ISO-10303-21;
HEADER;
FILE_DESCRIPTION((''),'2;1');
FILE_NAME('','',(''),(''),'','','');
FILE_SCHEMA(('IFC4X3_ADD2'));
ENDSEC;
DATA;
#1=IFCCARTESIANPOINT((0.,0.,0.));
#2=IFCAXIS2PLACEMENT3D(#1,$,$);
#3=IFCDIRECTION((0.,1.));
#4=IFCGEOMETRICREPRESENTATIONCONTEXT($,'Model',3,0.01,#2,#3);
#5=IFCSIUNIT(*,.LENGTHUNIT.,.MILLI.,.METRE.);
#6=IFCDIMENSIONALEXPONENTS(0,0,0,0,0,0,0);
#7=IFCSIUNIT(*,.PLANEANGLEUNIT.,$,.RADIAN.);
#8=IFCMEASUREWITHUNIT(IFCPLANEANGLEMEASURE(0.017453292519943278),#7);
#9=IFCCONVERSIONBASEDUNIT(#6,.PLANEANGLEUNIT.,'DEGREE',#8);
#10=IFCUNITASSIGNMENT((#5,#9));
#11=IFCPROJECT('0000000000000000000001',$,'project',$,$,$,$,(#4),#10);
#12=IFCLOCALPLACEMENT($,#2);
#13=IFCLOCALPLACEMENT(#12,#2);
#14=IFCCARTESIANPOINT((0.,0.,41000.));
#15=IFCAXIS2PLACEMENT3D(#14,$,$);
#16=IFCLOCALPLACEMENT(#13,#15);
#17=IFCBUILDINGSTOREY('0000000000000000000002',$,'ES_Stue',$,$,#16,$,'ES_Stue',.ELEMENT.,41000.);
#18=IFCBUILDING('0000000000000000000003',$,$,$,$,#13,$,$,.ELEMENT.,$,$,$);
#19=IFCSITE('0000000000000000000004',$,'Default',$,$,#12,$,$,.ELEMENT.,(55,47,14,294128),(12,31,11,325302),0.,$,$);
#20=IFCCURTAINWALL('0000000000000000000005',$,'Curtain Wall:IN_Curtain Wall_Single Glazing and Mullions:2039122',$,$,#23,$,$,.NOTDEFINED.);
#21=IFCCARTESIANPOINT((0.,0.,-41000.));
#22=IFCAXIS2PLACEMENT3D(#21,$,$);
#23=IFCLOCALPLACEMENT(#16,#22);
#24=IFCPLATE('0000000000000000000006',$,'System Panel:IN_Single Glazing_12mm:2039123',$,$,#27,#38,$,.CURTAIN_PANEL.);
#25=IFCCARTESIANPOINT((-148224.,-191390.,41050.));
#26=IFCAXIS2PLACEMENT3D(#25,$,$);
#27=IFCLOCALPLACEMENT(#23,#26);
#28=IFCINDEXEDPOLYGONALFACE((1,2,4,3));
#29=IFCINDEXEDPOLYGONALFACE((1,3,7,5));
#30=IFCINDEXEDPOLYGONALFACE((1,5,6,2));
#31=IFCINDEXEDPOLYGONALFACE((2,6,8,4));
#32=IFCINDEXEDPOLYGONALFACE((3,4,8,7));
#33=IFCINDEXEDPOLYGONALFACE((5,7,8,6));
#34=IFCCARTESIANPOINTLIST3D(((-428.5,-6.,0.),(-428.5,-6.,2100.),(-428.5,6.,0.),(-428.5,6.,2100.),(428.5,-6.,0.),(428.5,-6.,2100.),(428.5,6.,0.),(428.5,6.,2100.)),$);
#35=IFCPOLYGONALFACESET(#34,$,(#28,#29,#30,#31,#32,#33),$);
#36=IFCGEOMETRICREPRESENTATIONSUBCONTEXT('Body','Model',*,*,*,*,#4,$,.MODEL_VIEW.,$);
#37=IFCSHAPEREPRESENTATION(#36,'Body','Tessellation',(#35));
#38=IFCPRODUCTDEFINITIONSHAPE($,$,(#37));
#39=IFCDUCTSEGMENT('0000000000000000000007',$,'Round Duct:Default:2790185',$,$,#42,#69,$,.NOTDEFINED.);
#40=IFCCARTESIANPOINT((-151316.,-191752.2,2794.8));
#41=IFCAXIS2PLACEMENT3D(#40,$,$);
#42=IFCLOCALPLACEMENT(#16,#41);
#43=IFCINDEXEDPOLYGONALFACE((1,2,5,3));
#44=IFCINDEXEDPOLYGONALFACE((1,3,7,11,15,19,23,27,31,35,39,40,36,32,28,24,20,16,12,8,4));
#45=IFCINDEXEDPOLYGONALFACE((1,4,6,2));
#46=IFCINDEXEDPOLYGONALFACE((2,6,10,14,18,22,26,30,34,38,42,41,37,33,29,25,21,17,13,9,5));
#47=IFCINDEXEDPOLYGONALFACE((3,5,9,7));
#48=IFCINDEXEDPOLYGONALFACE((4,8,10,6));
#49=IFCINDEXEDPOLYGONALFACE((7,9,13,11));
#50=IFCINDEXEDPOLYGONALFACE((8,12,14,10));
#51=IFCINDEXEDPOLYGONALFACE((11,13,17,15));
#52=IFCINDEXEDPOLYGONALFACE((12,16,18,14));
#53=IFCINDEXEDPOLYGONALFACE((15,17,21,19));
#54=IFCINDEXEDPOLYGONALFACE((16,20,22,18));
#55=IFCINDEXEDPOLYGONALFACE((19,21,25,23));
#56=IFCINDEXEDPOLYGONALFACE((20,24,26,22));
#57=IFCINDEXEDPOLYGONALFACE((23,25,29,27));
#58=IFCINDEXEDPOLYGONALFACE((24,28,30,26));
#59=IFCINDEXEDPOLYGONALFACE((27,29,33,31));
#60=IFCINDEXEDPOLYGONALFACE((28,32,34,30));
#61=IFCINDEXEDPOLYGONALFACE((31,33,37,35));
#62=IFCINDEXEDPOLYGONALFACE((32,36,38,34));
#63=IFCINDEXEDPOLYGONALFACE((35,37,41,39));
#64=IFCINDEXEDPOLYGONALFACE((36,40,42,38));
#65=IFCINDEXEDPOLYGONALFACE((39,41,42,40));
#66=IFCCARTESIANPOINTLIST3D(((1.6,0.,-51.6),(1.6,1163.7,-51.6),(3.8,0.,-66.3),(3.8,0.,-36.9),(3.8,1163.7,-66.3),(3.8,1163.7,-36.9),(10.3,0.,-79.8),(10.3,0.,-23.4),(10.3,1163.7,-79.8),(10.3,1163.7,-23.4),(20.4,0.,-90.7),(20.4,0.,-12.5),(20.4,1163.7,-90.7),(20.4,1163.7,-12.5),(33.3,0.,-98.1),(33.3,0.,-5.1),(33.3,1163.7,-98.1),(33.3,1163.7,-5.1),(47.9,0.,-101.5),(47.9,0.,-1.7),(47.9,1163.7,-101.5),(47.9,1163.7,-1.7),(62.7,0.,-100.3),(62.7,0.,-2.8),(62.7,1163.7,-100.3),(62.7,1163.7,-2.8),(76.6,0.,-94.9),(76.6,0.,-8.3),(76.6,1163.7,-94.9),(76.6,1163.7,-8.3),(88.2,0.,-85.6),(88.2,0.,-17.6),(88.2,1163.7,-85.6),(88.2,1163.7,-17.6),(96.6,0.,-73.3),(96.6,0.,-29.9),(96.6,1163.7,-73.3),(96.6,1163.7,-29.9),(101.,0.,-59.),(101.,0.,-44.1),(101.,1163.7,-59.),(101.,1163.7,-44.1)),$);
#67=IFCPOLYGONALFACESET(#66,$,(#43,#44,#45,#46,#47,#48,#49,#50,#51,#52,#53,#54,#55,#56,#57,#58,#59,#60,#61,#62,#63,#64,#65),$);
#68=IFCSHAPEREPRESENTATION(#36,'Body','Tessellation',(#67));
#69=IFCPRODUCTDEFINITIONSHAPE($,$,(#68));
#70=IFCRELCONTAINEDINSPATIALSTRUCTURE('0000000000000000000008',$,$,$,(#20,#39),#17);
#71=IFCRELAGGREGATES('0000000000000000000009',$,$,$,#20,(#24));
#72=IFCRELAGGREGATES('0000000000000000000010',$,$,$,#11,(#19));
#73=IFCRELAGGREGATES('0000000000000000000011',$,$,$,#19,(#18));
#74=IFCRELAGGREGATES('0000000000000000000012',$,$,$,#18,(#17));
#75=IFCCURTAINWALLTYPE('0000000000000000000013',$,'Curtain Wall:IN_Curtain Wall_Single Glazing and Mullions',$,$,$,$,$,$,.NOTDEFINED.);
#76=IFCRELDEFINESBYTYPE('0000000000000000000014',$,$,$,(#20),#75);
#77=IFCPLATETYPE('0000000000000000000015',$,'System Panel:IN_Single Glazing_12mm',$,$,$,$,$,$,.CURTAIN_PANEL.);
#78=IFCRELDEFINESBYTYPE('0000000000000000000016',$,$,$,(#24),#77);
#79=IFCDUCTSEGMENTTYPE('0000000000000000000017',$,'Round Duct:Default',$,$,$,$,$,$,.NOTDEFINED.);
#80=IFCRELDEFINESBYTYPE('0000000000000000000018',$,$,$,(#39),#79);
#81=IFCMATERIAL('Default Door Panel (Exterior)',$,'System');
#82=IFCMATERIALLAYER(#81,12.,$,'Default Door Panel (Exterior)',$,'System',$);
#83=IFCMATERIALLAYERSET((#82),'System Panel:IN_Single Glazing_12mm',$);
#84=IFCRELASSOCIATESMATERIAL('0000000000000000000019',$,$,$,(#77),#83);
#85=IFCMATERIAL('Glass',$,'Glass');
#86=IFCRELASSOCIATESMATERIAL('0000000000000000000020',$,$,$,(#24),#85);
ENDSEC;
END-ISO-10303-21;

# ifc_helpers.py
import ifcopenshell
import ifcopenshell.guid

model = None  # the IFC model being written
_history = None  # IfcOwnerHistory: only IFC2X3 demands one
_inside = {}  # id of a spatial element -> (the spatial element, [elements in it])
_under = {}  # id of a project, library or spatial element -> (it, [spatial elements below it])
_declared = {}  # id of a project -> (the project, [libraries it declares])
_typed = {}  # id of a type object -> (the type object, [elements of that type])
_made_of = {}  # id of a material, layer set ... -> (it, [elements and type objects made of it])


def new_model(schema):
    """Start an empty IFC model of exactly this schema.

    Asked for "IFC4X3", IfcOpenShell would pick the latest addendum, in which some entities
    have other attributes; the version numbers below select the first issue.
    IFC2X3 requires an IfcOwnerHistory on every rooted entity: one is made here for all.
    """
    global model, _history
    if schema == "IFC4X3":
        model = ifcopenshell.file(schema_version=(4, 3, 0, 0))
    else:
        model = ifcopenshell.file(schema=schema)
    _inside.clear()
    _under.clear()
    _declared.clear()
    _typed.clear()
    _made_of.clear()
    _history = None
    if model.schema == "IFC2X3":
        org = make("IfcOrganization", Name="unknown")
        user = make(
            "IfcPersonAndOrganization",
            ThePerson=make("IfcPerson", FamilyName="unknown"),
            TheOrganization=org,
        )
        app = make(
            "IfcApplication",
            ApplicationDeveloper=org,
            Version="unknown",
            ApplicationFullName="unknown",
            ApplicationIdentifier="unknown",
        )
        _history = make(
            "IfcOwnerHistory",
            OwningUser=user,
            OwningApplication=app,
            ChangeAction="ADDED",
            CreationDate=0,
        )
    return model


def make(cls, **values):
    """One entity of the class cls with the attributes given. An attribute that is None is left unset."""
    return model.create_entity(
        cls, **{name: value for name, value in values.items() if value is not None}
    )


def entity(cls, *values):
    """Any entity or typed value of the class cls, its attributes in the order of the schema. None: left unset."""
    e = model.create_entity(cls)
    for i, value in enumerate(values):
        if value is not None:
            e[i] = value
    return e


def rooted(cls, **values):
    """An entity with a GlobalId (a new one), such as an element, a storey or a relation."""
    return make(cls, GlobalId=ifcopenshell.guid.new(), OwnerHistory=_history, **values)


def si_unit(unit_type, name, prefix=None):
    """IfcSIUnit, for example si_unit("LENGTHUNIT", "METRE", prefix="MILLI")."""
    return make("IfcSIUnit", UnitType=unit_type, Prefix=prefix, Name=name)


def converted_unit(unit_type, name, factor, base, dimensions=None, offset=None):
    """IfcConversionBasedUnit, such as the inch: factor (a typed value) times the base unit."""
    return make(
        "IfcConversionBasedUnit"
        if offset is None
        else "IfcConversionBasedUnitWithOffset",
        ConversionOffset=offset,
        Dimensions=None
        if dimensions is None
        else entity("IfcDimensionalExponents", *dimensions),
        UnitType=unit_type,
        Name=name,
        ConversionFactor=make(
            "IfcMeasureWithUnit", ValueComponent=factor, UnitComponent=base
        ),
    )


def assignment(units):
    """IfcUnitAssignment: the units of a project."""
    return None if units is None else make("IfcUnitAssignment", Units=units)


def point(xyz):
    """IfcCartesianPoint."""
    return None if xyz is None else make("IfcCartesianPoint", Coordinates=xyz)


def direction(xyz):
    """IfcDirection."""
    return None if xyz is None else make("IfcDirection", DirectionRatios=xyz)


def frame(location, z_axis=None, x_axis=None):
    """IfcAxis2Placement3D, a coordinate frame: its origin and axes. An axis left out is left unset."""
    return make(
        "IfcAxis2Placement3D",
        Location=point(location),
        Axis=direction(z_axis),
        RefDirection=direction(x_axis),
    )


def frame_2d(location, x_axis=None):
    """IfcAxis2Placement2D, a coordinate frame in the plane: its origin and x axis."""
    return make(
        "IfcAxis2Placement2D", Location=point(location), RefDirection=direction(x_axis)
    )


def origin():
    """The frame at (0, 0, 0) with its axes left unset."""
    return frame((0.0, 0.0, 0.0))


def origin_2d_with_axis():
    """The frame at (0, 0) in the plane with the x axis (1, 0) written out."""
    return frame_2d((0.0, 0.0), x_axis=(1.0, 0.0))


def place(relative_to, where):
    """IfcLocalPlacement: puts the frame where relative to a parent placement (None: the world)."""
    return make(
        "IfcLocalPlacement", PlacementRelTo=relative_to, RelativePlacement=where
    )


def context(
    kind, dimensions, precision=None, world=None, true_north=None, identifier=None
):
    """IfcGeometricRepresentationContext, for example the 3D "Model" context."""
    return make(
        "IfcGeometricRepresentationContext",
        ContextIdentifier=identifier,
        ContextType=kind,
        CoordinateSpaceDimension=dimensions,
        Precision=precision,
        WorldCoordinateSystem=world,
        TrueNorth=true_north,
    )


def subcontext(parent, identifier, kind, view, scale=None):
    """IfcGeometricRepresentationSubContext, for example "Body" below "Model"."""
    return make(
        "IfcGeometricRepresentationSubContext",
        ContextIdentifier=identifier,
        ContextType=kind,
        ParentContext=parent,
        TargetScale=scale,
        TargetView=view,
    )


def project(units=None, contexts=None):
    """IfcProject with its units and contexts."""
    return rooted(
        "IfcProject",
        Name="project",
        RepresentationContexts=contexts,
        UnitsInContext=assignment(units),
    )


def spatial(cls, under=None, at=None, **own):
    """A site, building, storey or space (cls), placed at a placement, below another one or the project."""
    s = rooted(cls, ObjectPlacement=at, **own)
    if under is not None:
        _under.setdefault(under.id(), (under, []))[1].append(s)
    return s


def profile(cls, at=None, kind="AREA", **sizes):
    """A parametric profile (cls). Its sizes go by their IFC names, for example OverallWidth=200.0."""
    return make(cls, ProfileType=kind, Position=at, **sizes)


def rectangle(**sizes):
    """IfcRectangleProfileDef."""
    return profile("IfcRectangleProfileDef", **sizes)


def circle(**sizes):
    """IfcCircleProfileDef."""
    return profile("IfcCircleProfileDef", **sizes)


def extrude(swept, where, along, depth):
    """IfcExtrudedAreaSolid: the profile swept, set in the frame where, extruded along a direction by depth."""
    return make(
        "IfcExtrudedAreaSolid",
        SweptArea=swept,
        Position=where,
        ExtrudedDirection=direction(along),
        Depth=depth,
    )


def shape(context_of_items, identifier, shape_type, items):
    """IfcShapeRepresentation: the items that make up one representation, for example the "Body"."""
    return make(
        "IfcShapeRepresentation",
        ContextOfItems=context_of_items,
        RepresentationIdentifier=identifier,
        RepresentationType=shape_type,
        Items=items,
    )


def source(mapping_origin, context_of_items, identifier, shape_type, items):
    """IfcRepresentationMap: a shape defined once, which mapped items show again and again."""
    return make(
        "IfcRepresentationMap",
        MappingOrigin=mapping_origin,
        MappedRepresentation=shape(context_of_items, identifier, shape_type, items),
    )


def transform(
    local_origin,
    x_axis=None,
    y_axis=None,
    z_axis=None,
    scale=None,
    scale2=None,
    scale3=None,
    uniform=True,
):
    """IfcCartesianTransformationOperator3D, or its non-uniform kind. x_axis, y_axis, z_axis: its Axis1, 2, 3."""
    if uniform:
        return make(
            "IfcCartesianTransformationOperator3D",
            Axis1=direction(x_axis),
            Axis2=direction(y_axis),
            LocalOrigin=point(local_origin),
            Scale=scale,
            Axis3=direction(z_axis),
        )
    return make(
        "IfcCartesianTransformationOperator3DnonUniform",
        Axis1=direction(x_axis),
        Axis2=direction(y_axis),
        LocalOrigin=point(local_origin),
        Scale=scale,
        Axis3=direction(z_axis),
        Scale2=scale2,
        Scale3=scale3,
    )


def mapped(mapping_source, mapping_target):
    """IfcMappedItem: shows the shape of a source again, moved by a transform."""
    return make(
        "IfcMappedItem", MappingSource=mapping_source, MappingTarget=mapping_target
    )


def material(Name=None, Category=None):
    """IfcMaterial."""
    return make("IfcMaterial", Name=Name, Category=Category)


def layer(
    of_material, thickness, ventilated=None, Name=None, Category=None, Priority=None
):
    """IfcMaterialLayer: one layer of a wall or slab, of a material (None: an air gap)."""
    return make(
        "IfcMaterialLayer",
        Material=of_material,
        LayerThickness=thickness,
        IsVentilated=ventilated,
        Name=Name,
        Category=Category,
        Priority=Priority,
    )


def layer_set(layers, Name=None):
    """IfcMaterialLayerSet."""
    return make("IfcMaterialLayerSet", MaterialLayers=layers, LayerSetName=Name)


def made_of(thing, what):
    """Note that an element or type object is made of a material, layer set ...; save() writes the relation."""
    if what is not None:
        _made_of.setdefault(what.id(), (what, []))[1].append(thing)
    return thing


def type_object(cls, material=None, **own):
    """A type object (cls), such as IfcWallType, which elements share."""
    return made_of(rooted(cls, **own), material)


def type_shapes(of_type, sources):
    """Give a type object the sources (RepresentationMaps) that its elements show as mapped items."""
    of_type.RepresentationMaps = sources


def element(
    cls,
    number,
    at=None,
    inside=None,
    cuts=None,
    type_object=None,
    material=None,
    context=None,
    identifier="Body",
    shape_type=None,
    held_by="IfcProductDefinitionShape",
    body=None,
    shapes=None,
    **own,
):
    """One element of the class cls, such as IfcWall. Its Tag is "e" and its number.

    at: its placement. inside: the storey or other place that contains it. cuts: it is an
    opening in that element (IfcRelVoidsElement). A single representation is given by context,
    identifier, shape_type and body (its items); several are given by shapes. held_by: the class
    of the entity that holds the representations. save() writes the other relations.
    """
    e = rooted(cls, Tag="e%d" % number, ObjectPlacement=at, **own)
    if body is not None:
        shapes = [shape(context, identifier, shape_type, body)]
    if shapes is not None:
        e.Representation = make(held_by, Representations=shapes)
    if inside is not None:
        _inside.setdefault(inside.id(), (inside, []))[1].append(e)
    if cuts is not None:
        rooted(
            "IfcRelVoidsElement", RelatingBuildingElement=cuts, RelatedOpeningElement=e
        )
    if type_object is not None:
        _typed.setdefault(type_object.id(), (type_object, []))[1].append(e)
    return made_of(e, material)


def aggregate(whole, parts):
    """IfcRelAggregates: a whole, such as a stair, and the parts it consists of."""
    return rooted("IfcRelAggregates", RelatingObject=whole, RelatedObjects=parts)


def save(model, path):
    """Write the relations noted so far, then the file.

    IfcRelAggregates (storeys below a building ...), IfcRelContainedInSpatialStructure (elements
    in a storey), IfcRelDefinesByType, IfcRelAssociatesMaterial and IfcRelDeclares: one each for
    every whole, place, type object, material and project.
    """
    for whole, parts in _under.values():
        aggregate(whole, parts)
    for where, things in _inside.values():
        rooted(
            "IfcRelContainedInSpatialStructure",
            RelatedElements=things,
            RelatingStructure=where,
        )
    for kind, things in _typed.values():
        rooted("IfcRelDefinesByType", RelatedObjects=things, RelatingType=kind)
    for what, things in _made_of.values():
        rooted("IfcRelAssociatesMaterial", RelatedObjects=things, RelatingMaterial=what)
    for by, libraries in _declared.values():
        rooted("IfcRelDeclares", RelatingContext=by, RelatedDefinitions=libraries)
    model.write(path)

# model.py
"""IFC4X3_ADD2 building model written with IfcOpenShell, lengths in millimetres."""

from ifc_helpers import new_model, entity, si_unit, converted_unit, direction, frame, frame_2d, origin, origin_2d_with_axis, place, context, subcontext, project, spatial, rectangle, circle, extrude, source, transform, mapped, material, layer, layer_set, type_object, type_shapes, element, aggregate, save


model = new_model("IFC4X3_ADD2")

# Units and contexts
model_context = context("Model", 3, precision=0.01, world=origin(), true_north=direction((0.0, 1.0)))
body_context = subcontext(model_context, "Body", "Model", "MODEL_VIEW")
ifc_project = project(units=[si_unit("LENGTHUNIT", "METRE", prefix="MILLI"), converted_unit("PLANEANGLEUNIT", "DEGREE", entity("IfcPlaneAngleMeasure", 0.017453292519943278), si_unit("PLANEANGLEUNIT", "RADIAN"), dimensions=[0, 0, 0, 0, 0, 0, 0])], contexts=[model_context])

# Site, building, storey
site_placement = place(None, origin())
site = spatial("IfcSite", under=ifc_project, at=site_placement, Name="Default", CompositionType="ELEMENT", RefLatitude=(55, 47, 14, 294128), RefLongitude=(12, 31, 11, 325302), RefElevation=0.0)
building_placement = place(site_placement, origin())
building = spatial("IfcBuilding", under=site, at=building_placement, CompositionType="ELEMENT")
storey_placement = place(building_placement, frame((0.0, 0.0, 41000.0)))
storey = spatial("IfcBuildingStorey", under=building, at=storey_placement, Name="ES_Stue", LongName="ES_Stue", CompositionType="ELEMENT", Elevation=41000.0)

# Curtain wall, plate
curtain_wall_type = type_object("IfcCurtainWallType", Name="Curtain Wall:IN_Curtain Wall_Single Glazing and Mullions", PredefinedType="NOTDEFINED")
curtain_wall_placement = place(storey_placement, frame((0.0, 0.0, -41000.0)))
curtain_wall = element("IfcCurtainWall", 1, at=curtain_wall_placement, inside=storey, type_object=curtain_wall_type, Name="Curtain Wall:IN_Curtain Wall_Single Glazing and Mullions:2039122", PredefinedType="NOTDEFINED")
ifc_material_1 = material(Name="Glass", Category="Glass")
ifc_material_2 = material(Name="Default Door Panel (Exterior)", Category="System")
ifc_layer_1 = layer(ifc_material_2, 12.0, Name="Default Door Panel (Exterior)", Category="System")
ifc_layer_set_1 = layer_set([ifc_layer_1], Name="System Panel:IN_Single Glazing_12mm")
plate_type = type_object("IfcPlateType", Name="System Panel:IN_Single Glazing_12mm", PredefinedType="CURTAIN_PANEL", material=ifc_layer_set_1)
shared_shape_1 = source(origin(), body_context, "Body", "SweptSolid", [
    extrude(rectangle(XDim=12.0, YDim=857.0, at=origin_2d_with_axis()), frame((0.0, 0.0, 0.0), z_axis=(0.0, 0.0, 1.0), x_axis=(0.0, 1.0, 0.0)), (0.0, 0.0, 1.0), 2100.0),
])
type_shapes(plate_type, [shared_shape_1])
plate_placement = place(curtain_wall_placement, frame((-148224.0, -191390.0, 41050.0)))
plate = element("IfcPlate", 2, at=plate_placement, type_object=plate_type, material=ifc_material_1, Name="System Panel:IN_Single Glazing_12mm:2039123", PredefinedType="CURTAIN_PANEL", context=body_context, shape_type="MappedRepresentation", body=[
    mapped(shared_shape_1, transform((0.0, 0.0, 0.0), scale=1.0)),
])
aggregate(curtain_wall, [plate])

# Duct segment
duct_segment_type = type_object("IfcDuctSegmentType", Name="Round Duct:Default", PredefinedType="NOTDEFINED")
duct_segment_placement = place(storey_placement, frame((-151316.0, -191752.2, 2794.8)))
element("IfcDuctSegment", 3, at=duct_segment_placement, inside=storey, type_object=duct_segment_type, Name="Round Duct:Default:2790185", PredefinedType="NOTDEFINED", context=body_context, shape_type="SweptSolid", body=[
    extrude(circle(Radius=50.0, at=frame_2d((0.0, 0.0), x_axis=(1.0, 0.0))), frame((51.6, 0.0, -51.6), z_axis=(0.0, 1.0, 0.0), x_axis=(-1.0, 0.0, 0.0)), (0.0, 0.0, 1.0), 1163.7),
])

save(model, "model.ifc")
